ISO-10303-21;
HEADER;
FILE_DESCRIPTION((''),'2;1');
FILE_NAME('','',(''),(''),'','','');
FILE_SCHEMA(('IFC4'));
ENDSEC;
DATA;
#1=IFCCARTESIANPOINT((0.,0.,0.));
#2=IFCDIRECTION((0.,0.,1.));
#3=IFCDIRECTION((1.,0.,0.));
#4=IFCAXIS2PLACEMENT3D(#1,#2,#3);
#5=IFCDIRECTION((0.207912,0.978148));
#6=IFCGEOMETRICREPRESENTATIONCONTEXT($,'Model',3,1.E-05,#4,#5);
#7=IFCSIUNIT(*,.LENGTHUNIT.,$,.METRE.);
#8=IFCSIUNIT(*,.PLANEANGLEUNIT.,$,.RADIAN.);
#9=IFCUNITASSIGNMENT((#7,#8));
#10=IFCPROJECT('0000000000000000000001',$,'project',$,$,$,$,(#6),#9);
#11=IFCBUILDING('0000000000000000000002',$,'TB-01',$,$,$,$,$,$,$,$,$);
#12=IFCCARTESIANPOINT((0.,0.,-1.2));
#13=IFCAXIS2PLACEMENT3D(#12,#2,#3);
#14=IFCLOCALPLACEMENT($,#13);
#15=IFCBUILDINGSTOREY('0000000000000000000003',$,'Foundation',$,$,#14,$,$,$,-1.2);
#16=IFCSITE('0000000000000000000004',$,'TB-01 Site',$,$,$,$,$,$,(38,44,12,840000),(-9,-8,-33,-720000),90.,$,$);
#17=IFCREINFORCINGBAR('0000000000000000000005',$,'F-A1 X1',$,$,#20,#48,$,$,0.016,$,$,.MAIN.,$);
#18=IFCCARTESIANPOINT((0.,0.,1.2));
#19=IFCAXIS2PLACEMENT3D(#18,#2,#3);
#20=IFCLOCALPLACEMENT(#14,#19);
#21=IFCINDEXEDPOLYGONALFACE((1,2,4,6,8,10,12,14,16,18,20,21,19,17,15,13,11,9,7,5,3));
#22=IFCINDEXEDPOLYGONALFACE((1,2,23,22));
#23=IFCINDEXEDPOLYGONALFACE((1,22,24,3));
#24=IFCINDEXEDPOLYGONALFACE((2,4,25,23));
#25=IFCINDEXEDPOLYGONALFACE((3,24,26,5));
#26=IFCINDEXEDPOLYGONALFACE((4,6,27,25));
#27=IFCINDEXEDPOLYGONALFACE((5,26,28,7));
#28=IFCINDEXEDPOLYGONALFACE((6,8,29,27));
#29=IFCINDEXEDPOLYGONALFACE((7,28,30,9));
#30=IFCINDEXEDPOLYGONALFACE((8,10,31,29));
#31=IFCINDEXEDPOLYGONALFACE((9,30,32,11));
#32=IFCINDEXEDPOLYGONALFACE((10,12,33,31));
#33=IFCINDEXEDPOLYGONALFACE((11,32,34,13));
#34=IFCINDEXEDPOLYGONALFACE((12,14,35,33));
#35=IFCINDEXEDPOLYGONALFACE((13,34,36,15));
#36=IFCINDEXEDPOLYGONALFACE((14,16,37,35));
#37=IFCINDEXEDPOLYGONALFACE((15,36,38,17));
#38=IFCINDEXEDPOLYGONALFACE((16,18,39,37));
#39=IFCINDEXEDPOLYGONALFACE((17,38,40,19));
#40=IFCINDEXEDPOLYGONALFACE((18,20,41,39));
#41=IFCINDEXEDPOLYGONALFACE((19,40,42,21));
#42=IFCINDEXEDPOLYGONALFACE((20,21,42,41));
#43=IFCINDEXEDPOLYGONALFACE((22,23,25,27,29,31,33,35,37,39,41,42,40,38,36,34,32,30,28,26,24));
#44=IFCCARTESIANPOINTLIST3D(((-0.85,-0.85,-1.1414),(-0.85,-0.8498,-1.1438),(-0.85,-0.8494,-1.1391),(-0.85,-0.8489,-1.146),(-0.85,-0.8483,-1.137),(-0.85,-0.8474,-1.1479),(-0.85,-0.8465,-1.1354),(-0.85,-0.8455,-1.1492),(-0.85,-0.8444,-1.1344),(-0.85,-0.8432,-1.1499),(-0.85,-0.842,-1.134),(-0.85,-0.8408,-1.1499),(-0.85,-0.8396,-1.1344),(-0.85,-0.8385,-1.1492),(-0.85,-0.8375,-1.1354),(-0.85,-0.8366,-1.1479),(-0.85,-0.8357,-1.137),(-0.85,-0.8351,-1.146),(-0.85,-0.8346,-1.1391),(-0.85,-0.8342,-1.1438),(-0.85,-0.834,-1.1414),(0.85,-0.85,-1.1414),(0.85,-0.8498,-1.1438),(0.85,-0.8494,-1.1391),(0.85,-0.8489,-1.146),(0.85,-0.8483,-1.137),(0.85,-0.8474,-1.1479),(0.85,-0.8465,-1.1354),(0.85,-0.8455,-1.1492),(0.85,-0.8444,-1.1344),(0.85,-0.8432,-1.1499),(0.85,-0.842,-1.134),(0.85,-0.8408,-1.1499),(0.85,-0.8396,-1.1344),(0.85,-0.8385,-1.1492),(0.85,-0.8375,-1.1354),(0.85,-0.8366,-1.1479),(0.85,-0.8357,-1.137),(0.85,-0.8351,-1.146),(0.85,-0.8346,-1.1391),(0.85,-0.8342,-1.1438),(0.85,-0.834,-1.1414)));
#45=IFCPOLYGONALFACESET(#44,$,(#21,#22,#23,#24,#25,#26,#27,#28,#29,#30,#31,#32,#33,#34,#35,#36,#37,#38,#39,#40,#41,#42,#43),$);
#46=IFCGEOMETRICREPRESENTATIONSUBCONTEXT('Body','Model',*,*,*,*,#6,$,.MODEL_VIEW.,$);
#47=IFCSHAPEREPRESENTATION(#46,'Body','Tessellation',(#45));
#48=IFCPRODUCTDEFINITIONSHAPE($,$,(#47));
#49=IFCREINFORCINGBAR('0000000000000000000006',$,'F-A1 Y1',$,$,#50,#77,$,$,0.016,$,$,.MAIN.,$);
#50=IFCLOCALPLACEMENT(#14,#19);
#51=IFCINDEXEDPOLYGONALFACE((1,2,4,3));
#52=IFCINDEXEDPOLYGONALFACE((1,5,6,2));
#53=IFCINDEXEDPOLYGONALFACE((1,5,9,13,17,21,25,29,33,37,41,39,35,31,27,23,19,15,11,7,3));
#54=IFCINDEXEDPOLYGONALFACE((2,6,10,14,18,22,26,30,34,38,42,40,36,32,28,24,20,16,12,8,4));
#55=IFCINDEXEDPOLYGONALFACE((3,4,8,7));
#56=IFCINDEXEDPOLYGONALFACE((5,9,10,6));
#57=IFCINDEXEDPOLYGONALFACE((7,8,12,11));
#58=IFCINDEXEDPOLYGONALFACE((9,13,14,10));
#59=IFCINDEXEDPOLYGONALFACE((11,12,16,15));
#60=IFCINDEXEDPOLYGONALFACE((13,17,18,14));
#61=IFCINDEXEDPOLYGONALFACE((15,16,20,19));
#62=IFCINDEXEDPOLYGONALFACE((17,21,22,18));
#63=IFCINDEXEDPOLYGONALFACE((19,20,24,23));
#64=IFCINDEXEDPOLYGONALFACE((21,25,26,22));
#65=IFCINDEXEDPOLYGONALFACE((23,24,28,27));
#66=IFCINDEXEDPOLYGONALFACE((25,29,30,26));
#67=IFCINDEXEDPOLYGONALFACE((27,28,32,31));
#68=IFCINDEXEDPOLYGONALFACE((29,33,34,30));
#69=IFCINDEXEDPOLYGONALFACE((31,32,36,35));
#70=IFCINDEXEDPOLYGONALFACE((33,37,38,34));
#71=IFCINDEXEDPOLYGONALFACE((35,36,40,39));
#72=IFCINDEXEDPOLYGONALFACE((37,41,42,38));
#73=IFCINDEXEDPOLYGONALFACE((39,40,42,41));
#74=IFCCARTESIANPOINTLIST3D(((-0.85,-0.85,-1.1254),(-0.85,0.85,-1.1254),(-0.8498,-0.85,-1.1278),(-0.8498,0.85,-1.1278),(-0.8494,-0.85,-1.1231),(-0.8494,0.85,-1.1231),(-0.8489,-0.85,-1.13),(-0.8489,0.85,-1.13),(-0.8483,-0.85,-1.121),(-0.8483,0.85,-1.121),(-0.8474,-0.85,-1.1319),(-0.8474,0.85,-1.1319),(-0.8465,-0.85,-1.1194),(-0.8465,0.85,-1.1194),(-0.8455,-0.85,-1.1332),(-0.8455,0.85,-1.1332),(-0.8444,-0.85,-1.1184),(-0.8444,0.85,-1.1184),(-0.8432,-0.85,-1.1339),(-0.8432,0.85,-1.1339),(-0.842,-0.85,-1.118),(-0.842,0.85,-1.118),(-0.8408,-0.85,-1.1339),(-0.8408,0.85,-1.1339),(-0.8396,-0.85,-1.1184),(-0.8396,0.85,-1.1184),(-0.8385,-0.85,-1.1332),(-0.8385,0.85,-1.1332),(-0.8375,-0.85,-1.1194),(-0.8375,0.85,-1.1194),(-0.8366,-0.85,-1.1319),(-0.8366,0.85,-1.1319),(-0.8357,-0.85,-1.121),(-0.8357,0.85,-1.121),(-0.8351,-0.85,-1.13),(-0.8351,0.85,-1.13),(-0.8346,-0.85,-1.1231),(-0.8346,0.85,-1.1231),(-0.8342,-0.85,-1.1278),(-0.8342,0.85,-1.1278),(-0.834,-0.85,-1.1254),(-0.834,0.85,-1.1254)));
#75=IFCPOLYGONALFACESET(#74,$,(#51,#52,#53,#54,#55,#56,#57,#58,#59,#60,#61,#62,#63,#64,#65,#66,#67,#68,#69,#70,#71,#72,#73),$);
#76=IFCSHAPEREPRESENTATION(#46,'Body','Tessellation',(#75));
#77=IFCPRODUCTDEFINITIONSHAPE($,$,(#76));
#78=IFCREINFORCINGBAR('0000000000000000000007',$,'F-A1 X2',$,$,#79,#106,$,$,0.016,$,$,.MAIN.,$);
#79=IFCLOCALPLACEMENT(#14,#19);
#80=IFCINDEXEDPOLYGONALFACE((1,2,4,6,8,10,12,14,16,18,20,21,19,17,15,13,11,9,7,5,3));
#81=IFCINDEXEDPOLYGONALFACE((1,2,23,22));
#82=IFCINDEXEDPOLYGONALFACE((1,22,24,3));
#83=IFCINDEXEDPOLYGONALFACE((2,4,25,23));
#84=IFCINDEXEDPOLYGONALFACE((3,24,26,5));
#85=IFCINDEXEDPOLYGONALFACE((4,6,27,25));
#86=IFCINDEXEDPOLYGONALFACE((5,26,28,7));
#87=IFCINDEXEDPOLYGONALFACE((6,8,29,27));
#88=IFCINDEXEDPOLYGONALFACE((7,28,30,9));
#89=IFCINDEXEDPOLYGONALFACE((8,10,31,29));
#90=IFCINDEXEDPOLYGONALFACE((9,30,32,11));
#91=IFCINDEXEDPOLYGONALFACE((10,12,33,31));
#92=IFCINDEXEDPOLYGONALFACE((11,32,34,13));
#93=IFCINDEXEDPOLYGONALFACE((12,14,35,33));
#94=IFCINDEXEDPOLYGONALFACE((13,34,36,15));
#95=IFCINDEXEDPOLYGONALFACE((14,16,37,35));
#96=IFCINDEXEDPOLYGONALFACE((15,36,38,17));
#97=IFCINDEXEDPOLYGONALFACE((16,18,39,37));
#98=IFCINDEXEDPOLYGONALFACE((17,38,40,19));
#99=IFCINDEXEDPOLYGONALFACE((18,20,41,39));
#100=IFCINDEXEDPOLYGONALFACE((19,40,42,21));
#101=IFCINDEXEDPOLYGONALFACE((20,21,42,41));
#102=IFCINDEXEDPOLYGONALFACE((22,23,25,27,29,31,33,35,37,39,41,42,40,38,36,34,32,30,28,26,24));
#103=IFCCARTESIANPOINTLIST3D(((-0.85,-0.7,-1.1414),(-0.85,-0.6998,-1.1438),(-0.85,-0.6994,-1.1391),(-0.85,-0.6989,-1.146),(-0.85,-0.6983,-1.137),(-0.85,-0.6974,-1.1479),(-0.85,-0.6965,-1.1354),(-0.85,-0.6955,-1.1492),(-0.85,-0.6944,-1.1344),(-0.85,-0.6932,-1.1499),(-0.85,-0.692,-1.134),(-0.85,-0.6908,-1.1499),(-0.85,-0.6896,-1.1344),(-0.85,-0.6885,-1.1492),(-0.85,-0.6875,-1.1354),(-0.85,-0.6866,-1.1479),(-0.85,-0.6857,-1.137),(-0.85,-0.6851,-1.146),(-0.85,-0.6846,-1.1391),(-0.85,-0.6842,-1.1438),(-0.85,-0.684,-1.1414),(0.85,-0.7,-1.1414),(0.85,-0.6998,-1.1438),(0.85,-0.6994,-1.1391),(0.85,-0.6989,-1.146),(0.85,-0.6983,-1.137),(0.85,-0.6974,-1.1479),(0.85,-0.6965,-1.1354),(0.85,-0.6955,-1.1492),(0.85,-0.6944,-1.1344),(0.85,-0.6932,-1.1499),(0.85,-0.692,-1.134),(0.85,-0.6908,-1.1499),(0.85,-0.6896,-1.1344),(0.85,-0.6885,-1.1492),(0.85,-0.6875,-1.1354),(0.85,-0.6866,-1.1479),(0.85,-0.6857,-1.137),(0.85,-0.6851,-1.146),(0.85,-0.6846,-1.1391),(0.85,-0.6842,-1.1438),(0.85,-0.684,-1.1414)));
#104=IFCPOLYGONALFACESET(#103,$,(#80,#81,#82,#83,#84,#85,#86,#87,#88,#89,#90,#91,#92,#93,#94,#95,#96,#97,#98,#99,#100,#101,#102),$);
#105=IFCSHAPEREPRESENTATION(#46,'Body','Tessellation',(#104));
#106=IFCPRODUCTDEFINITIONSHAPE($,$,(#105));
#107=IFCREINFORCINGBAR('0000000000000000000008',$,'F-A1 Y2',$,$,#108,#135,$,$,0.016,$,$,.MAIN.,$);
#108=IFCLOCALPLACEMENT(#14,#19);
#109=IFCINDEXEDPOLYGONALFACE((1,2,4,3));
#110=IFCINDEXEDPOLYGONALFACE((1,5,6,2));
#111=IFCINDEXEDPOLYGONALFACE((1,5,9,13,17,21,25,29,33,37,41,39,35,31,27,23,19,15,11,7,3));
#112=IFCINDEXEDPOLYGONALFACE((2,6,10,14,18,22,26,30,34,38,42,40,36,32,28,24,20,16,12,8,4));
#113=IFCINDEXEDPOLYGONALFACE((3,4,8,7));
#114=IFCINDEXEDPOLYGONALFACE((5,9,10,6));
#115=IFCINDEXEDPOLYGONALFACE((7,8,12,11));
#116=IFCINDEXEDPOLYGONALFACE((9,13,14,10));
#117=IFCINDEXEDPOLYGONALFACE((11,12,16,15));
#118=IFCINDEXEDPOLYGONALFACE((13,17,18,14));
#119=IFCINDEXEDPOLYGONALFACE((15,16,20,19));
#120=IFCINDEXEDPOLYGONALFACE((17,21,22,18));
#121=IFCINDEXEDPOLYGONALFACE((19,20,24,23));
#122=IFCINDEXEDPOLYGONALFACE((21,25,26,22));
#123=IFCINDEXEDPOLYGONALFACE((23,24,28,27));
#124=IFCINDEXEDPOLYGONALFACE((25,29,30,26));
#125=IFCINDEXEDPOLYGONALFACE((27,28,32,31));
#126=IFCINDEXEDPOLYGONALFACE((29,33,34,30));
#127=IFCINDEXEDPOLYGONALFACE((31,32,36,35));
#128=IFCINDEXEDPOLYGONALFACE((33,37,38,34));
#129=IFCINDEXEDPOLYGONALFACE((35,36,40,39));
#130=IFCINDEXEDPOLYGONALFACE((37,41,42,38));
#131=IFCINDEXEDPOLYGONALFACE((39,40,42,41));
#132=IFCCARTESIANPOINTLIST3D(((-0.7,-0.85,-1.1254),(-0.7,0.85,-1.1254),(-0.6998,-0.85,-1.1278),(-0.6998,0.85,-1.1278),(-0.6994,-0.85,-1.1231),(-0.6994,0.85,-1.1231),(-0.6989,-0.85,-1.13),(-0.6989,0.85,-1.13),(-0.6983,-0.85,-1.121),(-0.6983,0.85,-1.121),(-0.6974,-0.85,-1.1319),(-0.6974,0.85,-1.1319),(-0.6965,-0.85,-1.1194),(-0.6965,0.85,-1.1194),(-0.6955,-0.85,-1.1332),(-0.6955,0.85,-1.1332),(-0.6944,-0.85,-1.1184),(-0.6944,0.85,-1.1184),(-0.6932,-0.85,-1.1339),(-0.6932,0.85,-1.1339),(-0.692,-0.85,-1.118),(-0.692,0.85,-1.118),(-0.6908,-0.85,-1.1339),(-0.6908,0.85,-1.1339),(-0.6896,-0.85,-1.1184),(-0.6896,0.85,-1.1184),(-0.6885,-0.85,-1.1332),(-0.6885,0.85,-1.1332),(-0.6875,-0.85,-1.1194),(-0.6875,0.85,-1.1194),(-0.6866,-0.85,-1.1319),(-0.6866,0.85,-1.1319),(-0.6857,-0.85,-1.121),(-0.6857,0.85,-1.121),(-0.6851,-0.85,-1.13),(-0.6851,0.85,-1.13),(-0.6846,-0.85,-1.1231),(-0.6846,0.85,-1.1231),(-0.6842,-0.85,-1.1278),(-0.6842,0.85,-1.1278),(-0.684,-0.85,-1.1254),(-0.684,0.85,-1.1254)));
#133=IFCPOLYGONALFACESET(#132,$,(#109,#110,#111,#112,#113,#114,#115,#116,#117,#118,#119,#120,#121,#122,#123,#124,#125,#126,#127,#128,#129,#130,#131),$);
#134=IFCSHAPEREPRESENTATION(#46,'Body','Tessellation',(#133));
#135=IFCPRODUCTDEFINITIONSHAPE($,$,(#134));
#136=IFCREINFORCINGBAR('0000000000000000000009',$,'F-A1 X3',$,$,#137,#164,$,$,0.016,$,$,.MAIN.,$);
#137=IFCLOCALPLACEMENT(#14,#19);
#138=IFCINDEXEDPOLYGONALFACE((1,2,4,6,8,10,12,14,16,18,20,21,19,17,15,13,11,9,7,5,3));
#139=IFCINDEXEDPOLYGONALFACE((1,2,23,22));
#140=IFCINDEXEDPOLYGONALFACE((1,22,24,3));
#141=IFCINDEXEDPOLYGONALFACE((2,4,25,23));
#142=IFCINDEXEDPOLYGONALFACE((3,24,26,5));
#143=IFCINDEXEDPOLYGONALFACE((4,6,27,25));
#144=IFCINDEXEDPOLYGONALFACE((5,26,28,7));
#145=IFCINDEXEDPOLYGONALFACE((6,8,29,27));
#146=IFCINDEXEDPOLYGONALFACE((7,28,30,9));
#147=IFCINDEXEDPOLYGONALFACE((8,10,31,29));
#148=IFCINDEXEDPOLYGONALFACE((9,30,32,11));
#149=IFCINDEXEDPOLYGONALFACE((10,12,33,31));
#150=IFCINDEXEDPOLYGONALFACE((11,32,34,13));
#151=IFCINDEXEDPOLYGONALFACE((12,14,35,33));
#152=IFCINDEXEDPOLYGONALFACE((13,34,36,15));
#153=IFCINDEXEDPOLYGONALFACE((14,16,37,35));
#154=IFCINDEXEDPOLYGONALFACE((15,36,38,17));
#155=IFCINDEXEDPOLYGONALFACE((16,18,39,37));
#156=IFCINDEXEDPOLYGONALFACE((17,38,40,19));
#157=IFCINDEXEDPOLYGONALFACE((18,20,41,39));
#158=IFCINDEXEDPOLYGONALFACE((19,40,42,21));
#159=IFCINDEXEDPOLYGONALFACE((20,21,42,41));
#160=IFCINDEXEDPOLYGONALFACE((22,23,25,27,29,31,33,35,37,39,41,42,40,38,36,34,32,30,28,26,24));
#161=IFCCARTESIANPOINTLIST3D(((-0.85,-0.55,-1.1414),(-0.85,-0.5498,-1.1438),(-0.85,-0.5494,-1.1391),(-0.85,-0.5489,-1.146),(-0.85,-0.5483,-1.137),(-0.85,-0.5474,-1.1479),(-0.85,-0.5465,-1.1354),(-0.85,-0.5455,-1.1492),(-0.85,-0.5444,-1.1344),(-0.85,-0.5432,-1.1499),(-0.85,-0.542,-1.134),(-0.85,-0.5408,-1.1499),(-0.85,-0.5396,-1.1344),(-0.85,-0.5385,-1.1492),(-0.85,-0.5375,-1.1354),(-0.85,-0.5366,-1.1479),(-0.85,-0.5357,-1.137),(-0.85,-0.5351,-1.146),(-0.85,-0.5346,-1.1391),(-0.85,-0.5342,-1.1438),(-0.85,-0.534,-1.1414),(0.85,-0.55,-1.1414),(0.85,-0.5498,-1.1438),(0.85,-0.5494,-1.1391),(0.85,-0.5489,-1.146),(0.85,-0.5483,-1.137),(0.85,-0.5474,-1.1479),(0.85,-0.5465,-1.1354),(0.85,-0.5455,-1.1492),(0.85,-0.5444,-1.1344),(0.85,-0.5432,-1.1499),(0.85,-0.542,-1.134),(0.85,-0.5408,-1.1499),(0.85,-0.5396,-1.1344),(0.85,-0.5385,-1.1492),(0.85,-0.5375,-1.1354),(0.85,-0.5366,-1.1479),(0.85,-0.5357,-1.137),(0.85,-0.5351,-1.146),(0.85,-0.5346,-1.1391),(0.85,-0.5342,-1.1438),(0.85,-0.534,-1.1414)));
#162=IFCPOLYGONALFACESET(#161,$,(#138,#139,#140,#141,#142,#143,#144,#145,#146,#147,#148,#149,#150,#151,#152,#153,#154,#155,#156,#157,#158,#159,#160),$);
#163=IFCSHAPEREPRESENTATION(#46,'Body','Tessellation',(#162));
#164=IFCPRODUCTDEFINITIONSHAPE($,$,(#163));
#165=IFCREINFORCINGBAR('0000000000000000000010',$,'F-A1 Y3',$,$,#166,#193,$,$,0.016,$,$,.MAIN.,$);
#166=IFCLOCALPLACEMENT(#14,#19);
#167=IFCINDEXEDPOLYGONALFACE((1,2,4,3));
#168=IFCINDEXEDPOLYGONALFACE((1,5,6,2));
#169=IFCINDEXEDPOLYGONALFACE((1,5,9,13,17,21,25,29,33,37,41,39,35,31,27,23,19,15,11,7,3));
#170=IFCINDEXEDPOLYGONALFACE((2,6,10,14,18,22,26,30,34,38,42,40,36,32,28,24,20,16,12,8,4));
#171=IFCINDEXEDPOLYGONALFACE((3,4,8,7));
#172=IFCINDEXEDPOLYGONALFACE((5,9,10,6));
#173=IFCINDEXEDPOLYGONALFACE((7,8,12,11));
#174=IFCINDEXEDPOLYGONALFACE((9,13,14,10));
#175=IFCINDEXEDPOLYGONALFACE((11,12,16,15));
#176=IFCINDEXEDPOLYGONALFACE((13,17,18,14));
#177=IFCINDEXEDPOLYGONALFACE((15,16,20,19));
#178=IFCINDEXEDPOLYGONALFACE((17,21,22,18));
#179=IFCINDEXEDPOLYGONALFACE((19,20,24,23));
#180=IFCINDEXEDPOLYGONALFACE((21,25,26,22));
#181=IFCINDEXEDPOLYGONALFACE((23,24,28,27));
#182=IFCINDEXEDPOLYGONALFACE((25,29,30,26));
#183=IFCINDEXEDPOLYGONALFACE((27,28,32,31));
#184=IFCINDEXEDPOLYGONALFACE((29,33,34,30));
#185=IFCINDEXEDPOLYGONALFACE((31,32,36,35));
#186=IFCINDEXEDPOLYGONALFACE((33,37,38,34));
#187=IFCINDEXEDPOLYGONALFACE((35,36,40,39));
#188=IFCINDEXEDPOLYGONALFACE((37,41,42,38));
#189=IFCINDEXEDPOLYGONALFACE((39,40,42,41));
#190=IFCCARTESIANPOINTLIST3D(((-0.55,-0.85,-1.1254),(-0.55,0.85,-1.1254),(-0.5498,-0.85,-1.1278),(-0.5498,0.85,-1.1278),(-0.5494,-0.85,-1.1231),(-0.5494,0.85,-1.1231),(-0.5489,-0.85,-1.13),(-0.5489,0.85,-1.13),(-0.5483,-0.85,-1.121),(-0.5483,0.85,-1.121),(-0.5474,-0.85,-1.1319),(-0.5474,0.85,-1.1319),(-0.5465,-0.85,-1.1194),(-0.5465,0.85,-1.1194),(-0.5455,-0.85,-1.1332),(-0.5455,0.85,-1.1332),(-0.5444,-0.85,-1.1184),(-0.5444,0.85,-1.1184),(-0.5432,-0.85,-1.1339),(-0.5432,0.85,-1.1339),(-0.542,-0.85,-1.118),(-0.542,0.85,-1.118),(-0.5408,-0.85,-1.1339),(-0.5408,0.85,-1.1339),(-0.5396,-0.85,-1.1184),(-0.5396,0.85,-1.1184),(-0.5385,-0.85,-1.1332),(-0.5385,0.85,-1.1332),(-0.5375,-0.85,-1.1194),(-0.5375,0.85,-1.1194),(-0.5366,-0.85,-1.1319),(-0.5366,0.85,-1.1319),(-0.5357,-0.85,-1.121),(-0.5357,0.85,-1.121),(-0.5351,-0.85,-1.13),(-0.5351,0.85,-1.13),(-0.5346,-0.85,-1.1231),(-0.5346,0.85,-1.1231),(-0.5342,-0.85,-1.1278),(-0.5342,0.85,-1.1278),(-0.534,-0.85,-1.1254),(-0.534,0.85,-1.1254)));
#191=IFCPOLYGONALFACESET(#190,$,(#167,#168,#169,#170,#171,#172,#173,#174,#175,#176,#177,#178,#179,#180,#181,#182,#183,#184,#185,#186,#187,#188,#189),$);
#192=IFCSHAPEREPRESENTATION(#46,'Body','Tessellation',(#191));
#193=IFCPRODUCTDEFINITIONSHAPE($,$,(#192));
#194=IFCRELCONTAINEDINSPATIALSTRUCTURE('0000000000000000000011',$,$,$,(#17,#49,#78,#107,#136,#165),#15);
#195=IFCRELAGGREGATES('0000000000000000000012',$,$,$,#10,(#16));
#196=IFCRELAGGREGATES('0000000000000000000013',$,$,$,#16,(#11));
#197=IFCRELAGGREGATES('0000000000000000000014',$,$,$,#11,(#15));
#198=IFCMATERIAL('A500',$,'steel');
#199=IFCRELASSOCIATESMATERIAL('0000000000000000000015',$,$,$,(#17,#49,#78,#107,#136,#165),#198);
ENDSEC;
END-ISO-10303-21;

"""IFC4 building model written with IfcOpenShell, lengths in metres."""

from ifc_helpers import new_model, entity, si_unit, direction, frame, origin_with_axes, place, context, subcontext, project, spatial, material, element, save


model = new_model("IFC4")

# Units and contexts
model_context = context("Model", 3, precision=1e-05, world=origin_with_axes(), true_north=direction((0.207912, 0.978148)))
body_context = subcontext(model_context, "Body", "Model", "MODEL_VIEW")
ifc_project = project(units=[si_unit("LENGTHUNIT", "METRE"), si_unit("PLANEANGLEUNIT", "RADIAN")], contexts=[model_context])

# Site, building, storey
site = spatial("IfcSite", under=ifc_project, Name="TB-01 Site", RefLatitude=(38, 44, 12, 840000), RefLongitude=(-9, -8, -33, -720000), RefElevation=90.0)
building = spatial("IfcBuilding", under=site, Name="TB-01")
storey_placement = place(None, frame((0.0, 0.0, -1.2), z_axis=(0.0, 0.0, 1.0), x_axis=(1.0, 0.0, 0.0)))
storey = spatial("IfcBuildingStorey", under=building, at=storey_placement, Name="Foundation", Elevation=-1.2)

# Reinforcing bars
ifc_material_1 = material(Name="A500", Category="steel")
reinforcing_bar_1_placement = place(storey_placement, frame((0.0, 0.0, 1.2), z_axis=(0.0, 0.0, 1.0), x_axis=(1.0, 0.0, 0.0)))
element("IfcReinforcingBar", 1, at=reinforcing_bar_1_placement, inside=storey, material=ifc_material_1, Name="F-A1 X1", NominalDiameter=0.016, PredefinedType="MAIN", context=body_context, shape_type="AdvancedSweptSolid", body=[
    entity("IfcSweptDiskSolid", entity("IfcPolyline", [entity("IfcCartesianPoint", [-0.85, -0.842, -1.142]), entity("IfcCartesianPoint", [0.85, -0.842, -1.142])]), 0.008),
])
reinforcing_bar_2_placement = place(storey_placement, frame((0.0, 0.0, 1.2), z_axis=(0.0, 0.0, 1.0), x_axis=(1.0, 0.0, 0.0)))
element("IfcReinforcingBar", 2, at=reinforcing_bar_2_placement, inside=storey, material=ifc_material_1, Name="F-A1 Y1", NominalDiameter=0.016, PredefinedType="MAIN", context=body_context, shape_type="AdvancedSweptSolid", body=[
    entity("IfcSweptDiskSolid", entity("IfcPolyline", [entity("IfcCartesianPoint", [-0.842, -0.85, -1.126]), entity("IfcCartesianPoint", [-0.842, 0.85, -1.126])]), 0.008),
])
reinforcing_bar_3_placement = place(storey_placement, frame((0.0, 0.0, 1.2), z_axis=(0.0, 0.0, 1.0), x_axis=(1.0, 0.0, 0.0)))
element("IfcReinforcingBar", 3, at=reinforcing_bar_3_placement, inside=storey, material=ifc_material_1, Name="F-A1 X2", NominalDiameter=0.016, PredefinedType="MAIN", context=body_context, shape_type="AdvancedSweptSolid", body=[
    entity("IfcSweptDiskSolid", entity("IfcPolyline", [entity("IfcCartesianPoint", [-0.85, -0.692, -1.142]), entity("IfcCartesianPoint", [0.85, -0.692, -1.142])]), 0.008),
])
reinforcing_bar_4_placement = place(storey_placement, frame((0.0, 0.0, 1.2), z_axis=(0.0, 0.0, 1.0), x_axis=(1.0, 0.0, 0.0)))
element("IfcReinforcingBar", 4, at=reinforcing_bar_4_placement, inside=storey, material=ifc_material_1, Name="F-A1 Y2", NominalDiameter=0.016, PredefinedType="MAIN", context=body_context, shape_type="AdvancedSweptSolid", body=[
    entity("IfcSweptDiskSolid", entity("IfcPolyline", [entity("IfcCartesianPoint", [-0.692, -0.85, -1.126]), entity("IfcCartesianPoint", [-0.692, 0.85, -1.126])]), 0.008),
])
reinforcing_bar_5_placement = place(storey_placement, frame((0.0, 0.0, 1.2), z_axis=(0.0, 0.0, 1.0), x_axis=(1.0, 0.0, 0.0)))
element("IfcReinforcingBar", 5, at=reinforcing_bar_5_placement, inside=storey, material=ifc_material_1, Name="F-A1 X3", NominalDiameter=0.016, PredefinedType="MAIN", context=body_context, shape_type="AdvancedSweptSolid", body=[
    entity("IfcSweptDiskSolid", entity("IfcPolyline", [entity("IfcCartesianPoint", [-0.85, -0.542, -1.142]), entity("IfcCartesianPoint", [0.85, -0.542, -1.142])]), 0.008),
])
reinforcing_bar_6_placement = place(storey_placement, frame((0.0, 0.0, 1.2), z_axis=(0.0, 0.0, 1.0), x_axis=(1.0, 0.0, 0.0)))
element("IfcReinforcingBar", 6, at=reinforcing_bar_6_placement, inside=storey, material=ifc_material_1, Name="F-A1 Y3", NominalDiameter=0.016, PredefinedType="MAIN", context=body_context, shape_type="AdvancedSweptSolid", body=[
    entity("IfcSweptDiskSolid", entity("IfcPolyline", [entity("IfcCartesianPoint", [-0.542, -0.85, -1.126]), entity("IfcCartesianPoint", [-0.542, 0.85, -1.126])]), 0.008),
])

save(model, "model.ifc")
